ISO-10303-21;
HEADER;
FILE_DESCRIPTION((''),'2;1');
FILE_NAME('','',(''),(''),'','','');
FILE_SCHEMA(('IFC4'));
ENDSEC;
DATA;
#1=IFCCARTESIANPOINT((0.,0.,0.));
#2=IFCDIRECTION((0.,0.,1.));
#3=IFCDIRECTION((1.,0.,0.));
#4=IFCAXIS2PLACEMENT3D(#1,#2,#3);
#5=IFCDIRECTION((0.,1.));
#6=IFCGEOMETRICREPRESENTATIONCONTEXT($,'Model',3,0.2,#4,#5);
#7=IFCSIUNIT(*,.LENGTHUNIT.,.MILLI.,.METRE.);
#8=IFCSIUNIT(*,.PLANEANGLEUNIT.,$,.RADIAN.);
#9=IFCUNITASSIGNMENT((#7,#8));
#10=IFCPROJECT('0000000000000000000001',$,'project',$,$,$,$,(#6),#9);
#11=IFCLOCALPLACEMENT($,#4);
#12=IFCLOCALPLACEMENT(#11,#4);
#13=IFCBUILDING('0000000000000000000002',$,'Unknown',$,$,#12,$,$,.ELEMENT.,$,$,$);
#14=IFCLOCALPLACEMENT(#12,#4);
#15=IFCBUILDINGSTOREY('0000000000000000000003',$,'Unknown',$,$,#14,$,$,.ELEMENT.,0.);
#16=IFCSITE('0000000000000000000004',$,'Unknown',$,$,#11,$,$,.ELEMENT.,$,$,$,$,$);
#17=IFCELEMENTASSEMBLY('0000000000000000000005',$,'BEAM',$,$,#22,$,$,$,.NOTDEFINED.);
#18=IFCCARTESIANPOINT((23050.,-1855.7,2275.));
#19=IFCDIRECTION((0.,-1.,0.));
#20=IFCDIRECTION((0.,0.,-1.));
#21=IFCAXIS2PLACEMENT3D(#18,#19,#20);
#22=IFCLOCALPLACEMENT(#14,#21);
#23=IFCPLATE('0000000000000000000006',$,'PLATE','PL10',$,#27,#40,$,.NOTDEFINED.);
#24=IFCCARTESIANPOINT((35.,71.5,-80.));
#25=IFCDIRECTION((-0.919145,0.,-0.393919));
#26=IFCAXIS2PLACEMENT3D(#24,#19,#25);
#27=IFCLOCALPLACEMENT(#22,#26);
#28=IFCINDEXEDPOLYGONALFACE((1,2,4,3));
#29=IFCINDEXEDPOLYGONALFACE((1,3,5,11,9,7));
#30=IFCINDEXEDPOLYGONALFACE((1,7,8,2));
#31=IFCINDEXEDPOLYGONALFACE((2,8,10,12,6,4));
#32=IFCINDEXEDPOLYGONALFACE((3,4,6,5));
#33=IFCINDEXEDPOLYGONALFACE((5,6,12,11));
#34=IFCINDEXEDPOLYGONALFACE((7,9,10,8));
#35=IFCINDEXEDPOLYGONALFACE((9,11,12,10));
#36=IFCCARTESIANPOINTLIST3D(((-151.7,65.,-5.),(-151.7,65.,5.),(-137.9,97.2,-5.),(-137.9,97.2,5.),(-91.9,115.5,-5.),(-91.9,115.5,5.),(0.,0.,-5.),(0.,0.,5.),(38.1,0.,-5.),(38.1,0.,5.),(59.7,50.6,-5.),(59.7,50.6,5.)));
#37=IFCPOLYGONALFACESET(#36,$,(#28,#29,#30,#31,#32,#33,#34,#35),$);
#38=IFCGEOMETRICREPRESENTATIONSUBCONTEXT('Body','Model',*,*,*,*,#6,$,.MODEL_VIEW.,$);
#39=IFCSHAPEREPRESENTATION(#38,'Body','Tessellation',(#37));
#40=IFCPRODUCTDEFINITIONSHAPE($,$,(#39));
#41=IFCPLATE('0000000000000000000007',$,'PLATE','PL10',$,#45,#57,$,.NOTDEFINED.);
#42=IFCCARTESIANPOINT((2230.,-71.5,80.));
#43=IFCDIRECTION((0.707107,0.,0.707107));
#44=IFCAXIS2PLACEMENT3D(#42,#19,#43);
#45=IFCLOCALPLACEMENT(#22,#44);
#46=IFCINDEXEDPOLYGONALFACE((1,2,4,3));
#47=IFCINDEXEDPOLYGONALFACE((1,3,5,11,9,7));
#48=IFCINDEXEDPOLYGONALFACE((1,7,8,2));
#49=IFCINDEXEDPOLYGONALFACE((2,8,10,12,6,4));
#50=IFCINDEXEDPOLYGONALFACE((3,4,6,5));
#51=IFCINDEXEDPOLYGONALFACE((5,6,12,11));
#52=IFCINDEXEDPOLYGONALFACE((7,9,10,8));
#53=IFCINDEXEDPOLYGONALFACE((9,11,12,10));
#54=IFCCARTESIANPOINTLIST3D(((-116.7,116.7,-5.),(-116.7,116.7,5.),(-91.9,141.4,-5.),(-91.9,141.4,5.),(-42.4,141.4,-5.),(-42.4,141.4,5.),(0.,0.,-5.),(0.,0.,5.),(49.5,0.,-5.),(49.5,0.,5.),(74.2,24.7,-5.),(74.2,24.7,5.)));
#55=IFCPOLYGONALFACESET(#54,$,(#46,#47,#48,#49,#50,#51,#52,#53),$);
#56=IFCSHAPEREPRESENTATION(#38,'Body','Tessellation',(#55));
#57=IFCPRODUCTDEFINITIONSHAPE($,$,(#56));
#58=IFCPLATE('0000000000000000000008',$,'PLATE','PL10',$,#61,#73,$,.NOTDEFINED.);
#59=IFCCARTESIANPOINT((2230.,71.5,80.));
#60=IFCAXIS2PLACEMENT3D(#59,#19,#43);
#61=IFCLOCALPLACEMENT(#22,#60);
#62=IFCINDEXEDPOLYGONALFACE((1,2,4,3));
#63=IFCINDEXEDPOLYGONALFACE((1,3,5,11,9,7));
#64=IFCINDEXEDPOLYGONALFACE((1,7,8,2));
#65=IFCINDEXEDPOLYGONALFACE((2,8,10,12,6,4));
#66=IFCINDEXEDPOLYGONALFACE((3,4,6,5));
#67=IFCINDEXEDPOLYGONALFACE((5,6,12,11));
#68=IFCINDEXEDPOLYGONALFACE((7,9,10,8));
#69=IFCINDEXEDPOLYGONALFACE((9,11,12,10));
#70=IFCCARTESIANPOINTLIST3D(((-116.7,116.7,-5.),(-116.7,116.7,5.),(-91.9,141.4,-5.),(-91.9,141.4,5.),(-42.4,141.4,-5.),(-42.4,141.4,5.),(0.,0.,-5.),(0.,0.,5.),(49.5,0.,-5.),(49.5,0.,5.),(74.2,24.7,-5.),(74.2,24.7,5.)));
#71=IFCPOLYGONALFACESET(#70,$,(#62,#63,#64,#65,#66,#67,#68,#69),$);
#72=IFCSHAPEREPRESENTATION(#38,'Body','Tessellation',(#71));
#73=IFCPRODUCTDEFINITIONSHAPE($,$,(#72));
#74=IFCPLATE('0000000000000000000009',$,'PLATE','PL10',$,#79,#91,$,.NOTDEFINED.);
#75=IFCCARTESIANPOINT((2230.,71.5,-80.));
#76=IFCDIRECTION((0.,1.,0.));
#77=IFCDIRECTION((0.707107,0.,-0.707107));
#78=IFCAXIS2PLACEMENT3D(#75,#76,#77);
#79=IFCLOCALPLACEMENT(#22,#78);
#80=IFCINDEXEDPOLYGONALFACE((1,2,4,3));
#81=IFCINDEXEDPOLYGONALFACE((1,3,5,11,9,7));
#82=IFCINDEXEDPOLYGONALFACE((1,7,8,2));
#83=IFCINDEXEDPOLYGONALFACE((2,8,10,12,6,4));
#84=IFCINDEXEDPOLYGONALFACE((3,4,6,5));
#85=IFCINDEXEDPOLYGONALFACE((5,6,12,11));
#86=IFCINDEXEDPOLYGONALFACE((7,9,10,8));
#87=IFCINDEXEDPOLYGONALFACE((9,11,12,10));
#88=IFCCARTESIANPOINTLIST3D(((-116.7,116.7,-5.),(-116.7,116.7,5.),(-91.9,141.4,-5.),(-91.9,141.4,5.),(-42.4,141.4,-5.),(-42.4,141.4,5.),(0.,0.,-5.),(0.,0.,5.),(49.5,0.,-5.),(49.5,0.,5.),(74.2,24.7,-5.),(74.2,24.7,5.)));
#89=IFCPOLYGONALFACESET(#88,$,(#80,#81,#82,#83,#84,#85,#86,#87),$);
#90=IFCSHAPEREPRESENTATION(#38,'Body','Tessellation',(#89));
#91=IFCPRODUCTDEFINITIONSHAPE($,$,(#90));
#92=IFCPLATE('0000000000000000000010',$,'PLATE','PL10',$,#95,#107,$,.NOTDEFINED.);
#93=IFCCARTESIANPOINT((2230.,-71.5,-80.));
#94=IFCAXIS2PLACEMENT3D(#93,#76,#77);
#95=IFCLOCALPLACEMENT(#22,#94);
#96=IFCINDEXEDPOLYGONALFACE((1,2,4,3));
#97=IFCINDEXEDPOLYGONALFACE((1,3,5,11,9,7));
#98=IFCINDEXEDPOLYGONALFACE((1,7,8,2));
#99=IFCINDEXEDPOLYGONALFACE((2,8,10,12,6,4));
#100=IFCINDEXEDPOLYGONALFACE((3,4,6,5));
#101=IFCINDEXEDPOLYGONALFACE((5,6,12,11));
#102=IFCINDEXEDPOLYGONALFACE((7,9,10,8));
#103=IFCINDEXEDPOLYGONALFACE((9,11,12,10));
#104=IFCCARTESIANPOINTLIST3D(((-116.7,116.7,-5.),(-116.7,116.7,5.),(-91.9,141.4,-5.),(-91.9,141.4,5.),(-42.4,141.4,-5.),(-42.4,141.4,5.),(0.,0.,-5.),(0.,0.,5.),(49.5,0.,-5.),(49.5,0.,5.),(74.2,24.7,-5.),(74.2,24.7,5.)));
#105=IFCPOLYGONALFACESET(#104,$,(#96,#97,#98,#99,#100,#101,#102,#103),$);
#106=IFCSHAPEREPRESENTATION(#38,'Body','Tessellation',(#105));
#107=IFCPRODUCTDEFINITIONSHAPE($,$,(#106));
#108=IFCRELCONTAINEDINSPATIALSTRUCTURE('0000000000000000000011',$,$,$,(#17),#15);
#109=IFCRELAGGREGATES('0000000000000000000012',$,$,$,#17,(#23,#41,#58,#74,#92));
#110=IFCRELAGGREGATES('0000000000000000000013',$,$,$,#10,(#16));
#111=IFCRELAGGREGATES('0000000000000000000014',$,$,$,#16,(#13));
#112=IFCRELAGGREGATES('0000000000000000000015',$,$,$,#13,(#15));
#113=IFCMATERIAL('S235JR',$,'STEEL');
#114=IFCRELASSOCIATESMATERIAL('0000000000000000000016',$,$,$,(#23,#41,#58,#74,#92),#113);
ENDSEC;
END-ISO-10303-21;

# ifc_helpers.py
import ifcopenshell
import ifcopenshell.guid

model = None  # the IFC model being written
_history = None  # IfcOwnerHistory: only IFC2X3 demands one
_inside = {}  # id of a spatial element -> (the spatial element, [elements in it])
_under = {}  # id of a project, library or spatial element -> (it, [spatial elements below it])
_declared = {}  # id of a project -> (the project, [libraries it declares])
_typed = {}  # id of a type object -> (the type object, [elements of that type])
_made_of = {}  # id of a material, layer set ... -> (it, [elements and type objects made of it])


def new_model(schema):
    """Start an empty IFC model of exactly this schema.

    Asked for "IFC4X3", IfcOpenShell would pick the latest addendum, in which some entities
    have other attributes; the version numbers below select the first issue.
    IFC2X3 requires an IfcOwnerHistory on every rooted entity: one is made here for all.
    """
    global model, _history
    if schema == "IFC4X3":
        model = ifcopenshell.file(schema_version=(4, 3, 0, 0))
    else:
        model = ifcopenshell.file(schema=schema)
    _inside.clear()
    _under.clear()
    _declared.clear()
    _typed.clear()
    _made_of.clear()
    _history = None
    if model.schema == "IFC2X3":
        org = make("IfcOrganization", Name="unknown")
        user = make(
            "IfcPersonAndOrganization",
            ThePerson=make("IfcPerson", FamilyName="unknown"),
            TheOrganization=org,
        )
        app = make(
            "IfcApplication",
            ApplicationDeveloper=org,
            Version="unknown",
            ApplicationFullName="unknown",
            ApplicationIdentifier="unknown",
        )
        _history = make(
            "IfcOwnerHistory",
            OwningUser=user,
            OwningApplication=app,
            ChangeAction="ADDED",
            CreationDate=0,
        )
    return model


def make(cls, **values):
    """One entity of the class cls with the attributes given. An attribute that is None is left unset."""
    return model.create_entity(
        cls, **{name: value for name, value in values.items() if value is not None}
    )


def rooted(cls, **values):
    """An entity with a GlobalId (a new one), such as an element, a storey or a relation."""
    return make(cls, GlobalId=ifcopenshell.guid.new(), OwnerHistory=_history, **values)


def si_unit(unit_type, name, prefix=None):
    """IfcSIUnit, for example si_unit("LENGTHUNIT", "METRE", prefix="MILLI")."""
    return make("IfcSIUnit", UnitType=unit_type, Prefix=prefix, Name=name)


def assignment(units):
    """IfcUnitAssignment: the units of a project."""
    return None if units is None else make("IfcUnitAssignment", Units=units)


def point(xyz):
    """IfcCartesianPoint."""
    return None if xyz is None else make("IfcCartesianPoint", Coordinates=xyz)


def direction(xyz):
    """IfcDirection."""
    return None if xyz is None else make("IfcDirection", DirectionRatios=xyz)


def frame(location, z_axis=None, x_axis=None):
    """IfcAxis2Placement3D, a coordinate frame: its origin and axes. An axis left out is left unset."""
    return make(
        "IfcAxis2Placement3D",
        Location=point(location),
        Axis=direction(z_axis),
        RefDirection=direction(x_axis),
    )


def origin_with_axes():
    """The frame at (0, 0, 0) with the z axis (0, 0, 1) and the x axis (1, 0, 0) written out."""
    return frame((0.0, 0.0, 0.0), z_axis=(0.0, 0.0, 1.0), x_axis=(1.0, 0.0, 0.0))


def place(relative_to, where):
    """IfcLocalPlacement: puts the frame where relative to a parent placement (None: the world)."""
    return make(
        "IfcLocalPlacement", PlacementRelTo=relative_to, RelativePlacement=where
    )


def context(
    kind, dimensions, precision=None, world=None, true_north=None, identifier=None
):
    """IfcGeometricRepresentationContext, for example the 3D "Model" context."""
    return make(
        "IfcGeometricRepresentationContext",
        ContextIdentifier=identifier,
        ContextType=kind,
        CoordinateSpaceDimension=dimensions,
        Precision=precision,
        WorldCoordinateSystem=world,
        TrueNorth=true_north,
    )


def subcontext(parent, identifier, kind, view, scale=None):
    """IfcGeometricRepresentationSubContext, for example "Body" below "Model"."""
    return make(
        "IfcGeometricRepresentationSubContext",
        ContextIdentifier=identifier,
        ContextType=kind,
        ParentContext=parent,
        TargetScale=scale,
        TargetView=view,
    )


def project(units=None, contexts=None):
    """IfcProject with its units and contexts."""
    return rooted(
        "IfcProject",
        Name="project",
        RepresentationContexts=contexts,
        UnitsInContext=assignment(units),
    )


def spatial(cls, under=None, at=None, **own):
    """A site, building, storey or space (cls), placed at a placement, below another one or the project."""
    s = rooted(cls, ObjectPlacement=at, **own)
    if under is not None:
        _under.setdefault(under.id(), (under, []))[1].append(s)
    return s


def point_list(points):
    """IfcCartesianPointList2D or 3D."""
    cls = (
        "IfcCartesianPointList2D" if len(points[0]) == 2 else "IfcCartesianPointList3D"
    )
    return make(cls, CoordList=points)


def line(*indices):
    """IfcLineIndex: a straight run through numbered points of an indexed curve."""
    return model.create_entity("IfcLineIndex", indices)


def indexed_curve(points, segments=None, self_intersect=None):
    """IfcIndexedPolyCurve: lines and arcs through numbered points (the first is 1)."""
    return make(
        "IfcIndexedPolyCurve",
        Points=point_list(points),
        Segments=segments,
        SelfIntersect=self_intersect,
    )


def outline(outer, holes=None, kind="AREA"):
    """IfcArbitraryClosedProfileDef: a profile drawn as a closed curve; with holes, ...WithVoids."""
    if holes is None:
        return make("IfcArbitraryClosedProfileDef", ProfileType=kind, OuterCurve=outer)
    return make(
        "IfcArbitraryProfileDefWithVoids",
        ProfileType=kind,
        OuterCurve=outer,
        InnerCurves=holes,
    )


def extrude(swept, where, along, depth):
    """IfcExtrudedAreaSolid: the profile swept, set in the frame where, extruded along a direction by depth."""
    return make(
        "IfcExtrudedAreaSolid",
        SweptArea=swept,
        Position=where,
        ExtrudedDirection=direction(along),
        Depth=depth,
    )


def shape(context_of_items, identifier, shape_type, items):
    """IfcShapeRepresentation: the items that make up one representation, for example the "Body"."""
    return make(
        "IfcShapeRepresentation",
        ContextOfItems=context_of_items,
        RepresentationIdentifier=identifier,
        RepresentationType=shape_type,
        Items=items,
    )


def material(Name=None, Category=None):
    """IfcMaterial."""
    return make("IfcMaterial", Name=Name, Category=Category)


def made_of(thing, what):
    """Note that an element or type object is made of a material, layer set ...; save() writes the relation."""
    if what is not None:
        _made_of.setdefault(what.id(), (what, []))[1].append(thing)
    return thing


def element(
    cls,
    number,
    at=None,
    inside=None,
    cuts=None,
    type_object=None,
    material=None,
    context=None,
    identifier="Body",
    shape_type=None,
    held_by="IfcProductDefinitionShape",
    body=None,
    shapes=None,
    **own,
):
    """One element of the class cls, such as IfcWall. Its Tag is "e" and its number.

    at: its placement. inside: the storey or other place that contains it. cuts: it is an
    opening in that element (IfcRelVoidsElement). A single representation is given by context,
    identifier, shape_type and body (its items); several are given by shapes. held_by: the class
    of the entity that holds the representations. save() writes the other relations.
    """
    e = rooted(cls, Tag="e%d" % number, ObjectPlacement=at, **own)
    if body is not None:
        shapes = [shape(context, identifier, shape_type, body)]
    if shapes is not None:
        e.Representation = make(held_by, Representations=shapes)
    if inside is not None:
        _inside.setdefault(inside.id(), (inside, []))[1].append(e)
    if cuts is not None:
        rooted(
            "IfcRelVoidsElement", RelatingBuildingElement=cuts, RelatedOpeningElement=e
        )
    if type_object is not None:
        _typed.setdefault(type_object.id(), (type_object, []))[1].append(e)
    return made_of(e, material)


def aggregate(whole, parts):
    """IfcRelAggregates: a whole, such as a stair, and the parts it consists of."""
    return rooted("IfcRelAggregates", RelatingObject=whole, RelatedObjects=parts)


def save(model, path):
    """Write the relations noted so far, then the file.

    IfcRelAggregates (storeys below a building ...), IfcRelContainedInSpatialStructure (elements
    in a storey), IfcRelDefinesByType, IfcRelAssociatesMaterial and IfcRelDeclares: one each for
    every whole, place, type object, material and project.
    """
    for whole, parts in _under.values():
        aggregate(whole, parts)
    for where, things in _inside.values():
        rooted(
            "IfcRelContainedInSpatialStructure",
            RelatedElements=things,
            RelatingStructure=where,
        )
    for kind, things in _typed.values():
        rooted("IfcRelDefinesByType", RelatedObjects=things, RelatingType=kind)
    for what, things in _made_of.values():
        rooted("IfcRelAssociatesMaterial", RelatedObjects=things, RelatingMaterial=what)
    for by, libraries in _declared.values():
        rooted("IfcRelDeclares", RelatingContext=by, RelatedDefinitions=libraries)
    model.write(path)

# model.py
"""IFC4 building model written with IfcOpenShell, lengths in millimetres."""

from ifc_helpers import new_model, si_unit, direction, frame, origin_with_axes, place, context, subcontext, project, spatial, line, indexed_curve, outline, extrude, material, element, aggregate, save


model = new_model("IFC4")

# Units and contexts
model_context = context("Model", 3, precision=0.2, world=origin_with_axes(), true_north=direction((0.0, 1.0)))
body_context = subcontext(model_context, "Body", "Model", "MODEL_VIEW")
ifc_project = project(units=[si_unit("LENGTHUNIT", "METRE", prefix="MILLI"), si_unit("PLANEANGLEUNIT", "RADIAN")], contexts=[model_context])

# Site, building, storey
site_placement = place(None, origin_with_axes())
site = spatial("IfcSite", under=ifc_project, at=site_placement, Name="Unknown", CompositionType="ELEMENT")
building_placement = place(site_placement, origin_with_axes())
building = spatial("IfcBuilding", under=site, at=building_placement, Name="Unknown", CompositionType="ELEMENT")
storey_placement = place(building_placement, origin_with_axes())
storey = spatial("IfcBuildingStorey", under=building, at=storey_placement, Name="Unknown", CompositionType="ELEMENT", Elevation=0.0)

# Shared definitions
ifc_material_1 = material(Name="S235JR", Category="STEEL")

# Element assembly
assembly_1_placement = place(storey_placement, frame((23050.0, -1855.7, 2275.0), z_axis=(0.0, -1.0, 0.0), x_axis=(0.0, 0.0, -1.0)))
assembly_1 = element("IfcElementAssembly", 1, at=assembly_1_placement, inside=storey, Name="BEAM", PredefinedType="NOTDEFINED")

# Plates
plate_1_placement = place(assembly_1_placement, frame((35.0, 71.5, -80.0), z_axis=(0.0, -1.0, 0.0), x_axis=(-0.919145, 0.0, -0.393919)))
plate_1 = element("IfcPlate", 2, at=plate_1_placement, material=ifc_material_1, Name="PLATE", Description="PL10", PredefinedType="NOTDEFINED", context=body_context, shape_type="SolidModel", body=[
    extrude(outline(indexed_curve([(0.0, 0.0), (38.1, 0.0), (59.7, 50.6), (-91.9, 115.5), (-137.9, 97.2), (-151.7, 65.0)], segments=[line(1, 2, 3, 4, 5, 6, 1)])), frame((0.0, 0.0, 5.0), z_axis=(0.0, 0.0, 1.0), x_axis=(1.0, 0.0, 0.0)), (0.0, 0.0, -1.0), 10.0),
])
plate_2_placement = place(assembly_1_placement, frame((2230.0, -71.5, 80.0), z_axis=(0.0, -1.0, 0.0), x_axis=(0.707107, 0.0, 0.707107)))
plate_2 = element("IfcPlate", 3, at=plate_2_placement, material=ifc_material_1, Name="PLATE", Description="PL10", PredefinedType="NOTDEFINED", context=body_context, shape_type="SolidModel", body=[
    extrude(outline(indexed_curve([(0.0, 0.0), (49.5, 0.0), (74.2, 24.7), (-42.4, 141.4), (-91.9, 141.4), (-116.7, 116.7)], segments=[line(1, 2, 3, 4, 5, 6, 1)])), frame((0.0, 0.0, 5.0), z_axis=(0.0, 0.0, 1.0), x_axis=(1.0, 0.0, 0.0)), (0.0, 0.0, -1.0), 10.0),
])
plate_3_placement = place(assembly_1_placement, frame((2230.0, 71.5, 80.0), z_axis=(0.0, -1.0, 0.0), x_axis=(0.707107, 0.0, 0.707107)))
plate_3 = element("IfcPlate", 4, at=plate_3_placement, material=ifc_material_1, Name="PLATE", Description="PL10", PredefinedType="NOTDEFINED", context=body_context, shape_type="SolidModel", body=[
    extrude(outline(indexed_curve([(0.0, 0.0), (49.5, 0.0), (74.2, 24.7), (-42.4, 141.4), (-91.9, 141.4), (-116.7, 116.7)], segments=[line(1, 2, 3, 4, 5, 6, 1)])), frame((0.0, 0.0, 5.0), z_axis=(0.0, 0.0, 1.0), x_axis=(1.0, 0.0, 0.0)), (0.0, 0.0, -1.0), 10.0),
])
plate_4_placement = place(assembly_1_placement, frame((2230.0, 71.5, -80.0), z_axis=(0.0, 1.0, 0.0), x_axis=(0.707107, 0.0, -0.707107)))
plate_4 = element("IfcPlate", 5, at=plate_4_placement, material=ifc_material_1, Name="PLATE", Description="PL10", PredefinedType="NOTDEFINED", context=body_context, shape_type="SolidModel", body=[
    extrude(outline(indexed_curve([(0.0, 0.0), (49.5, 0.0), (74.2, 24.7), (-42.4, 141.4), (-91.9, 141.4), (-116.7, 116.7)], segments=[line(1, 2, 3, 4, 5, 6, 1)])), frame((0.0, 0.0, 5.0), z_axis=(0.0, 0.0, 1.0), x_axis=(1.0, 0.0, 0.0)), (0.0, 0.0, -1.0), 10.0),
])
plate_5_placement = place(assembly_1_placement, frame((2230.0, -71.5, -80.0), z_axis=(0.0, 1.0, 0.0), x_axis=(0.707107, 0.0, -0.707107)))
plate_5 = element("IfcPlate", 6, at=plate_5_placement, material=ifc_material_1, Name="PLATE", Description="PL10", PredefinedType="NOTDEFINED", context=body_context, shape_type="SolidModel", body=[
    extrude(outline(indexed_curve([(0.0, 0.0), (49.5, 0.0), (74.2, 24.7), (-42.4, 141.4), (-91.9, 141.4), (-116.7, 116.7)], segments=[line(1, 2, 3, 4, 5, 6, 1)])), frame((0.0, 0.0, 5.0), z_axis=(0.0, 0.0, 1.0), x_axis=(1.0, 0.0, 0.0)), (0.0, 0.0, -1.0), 10.0),
])

aggregate(assembly_1, [plate_1, plate_2, plate_3, plate_4, plate_5])

save(model, "model.ifc")
